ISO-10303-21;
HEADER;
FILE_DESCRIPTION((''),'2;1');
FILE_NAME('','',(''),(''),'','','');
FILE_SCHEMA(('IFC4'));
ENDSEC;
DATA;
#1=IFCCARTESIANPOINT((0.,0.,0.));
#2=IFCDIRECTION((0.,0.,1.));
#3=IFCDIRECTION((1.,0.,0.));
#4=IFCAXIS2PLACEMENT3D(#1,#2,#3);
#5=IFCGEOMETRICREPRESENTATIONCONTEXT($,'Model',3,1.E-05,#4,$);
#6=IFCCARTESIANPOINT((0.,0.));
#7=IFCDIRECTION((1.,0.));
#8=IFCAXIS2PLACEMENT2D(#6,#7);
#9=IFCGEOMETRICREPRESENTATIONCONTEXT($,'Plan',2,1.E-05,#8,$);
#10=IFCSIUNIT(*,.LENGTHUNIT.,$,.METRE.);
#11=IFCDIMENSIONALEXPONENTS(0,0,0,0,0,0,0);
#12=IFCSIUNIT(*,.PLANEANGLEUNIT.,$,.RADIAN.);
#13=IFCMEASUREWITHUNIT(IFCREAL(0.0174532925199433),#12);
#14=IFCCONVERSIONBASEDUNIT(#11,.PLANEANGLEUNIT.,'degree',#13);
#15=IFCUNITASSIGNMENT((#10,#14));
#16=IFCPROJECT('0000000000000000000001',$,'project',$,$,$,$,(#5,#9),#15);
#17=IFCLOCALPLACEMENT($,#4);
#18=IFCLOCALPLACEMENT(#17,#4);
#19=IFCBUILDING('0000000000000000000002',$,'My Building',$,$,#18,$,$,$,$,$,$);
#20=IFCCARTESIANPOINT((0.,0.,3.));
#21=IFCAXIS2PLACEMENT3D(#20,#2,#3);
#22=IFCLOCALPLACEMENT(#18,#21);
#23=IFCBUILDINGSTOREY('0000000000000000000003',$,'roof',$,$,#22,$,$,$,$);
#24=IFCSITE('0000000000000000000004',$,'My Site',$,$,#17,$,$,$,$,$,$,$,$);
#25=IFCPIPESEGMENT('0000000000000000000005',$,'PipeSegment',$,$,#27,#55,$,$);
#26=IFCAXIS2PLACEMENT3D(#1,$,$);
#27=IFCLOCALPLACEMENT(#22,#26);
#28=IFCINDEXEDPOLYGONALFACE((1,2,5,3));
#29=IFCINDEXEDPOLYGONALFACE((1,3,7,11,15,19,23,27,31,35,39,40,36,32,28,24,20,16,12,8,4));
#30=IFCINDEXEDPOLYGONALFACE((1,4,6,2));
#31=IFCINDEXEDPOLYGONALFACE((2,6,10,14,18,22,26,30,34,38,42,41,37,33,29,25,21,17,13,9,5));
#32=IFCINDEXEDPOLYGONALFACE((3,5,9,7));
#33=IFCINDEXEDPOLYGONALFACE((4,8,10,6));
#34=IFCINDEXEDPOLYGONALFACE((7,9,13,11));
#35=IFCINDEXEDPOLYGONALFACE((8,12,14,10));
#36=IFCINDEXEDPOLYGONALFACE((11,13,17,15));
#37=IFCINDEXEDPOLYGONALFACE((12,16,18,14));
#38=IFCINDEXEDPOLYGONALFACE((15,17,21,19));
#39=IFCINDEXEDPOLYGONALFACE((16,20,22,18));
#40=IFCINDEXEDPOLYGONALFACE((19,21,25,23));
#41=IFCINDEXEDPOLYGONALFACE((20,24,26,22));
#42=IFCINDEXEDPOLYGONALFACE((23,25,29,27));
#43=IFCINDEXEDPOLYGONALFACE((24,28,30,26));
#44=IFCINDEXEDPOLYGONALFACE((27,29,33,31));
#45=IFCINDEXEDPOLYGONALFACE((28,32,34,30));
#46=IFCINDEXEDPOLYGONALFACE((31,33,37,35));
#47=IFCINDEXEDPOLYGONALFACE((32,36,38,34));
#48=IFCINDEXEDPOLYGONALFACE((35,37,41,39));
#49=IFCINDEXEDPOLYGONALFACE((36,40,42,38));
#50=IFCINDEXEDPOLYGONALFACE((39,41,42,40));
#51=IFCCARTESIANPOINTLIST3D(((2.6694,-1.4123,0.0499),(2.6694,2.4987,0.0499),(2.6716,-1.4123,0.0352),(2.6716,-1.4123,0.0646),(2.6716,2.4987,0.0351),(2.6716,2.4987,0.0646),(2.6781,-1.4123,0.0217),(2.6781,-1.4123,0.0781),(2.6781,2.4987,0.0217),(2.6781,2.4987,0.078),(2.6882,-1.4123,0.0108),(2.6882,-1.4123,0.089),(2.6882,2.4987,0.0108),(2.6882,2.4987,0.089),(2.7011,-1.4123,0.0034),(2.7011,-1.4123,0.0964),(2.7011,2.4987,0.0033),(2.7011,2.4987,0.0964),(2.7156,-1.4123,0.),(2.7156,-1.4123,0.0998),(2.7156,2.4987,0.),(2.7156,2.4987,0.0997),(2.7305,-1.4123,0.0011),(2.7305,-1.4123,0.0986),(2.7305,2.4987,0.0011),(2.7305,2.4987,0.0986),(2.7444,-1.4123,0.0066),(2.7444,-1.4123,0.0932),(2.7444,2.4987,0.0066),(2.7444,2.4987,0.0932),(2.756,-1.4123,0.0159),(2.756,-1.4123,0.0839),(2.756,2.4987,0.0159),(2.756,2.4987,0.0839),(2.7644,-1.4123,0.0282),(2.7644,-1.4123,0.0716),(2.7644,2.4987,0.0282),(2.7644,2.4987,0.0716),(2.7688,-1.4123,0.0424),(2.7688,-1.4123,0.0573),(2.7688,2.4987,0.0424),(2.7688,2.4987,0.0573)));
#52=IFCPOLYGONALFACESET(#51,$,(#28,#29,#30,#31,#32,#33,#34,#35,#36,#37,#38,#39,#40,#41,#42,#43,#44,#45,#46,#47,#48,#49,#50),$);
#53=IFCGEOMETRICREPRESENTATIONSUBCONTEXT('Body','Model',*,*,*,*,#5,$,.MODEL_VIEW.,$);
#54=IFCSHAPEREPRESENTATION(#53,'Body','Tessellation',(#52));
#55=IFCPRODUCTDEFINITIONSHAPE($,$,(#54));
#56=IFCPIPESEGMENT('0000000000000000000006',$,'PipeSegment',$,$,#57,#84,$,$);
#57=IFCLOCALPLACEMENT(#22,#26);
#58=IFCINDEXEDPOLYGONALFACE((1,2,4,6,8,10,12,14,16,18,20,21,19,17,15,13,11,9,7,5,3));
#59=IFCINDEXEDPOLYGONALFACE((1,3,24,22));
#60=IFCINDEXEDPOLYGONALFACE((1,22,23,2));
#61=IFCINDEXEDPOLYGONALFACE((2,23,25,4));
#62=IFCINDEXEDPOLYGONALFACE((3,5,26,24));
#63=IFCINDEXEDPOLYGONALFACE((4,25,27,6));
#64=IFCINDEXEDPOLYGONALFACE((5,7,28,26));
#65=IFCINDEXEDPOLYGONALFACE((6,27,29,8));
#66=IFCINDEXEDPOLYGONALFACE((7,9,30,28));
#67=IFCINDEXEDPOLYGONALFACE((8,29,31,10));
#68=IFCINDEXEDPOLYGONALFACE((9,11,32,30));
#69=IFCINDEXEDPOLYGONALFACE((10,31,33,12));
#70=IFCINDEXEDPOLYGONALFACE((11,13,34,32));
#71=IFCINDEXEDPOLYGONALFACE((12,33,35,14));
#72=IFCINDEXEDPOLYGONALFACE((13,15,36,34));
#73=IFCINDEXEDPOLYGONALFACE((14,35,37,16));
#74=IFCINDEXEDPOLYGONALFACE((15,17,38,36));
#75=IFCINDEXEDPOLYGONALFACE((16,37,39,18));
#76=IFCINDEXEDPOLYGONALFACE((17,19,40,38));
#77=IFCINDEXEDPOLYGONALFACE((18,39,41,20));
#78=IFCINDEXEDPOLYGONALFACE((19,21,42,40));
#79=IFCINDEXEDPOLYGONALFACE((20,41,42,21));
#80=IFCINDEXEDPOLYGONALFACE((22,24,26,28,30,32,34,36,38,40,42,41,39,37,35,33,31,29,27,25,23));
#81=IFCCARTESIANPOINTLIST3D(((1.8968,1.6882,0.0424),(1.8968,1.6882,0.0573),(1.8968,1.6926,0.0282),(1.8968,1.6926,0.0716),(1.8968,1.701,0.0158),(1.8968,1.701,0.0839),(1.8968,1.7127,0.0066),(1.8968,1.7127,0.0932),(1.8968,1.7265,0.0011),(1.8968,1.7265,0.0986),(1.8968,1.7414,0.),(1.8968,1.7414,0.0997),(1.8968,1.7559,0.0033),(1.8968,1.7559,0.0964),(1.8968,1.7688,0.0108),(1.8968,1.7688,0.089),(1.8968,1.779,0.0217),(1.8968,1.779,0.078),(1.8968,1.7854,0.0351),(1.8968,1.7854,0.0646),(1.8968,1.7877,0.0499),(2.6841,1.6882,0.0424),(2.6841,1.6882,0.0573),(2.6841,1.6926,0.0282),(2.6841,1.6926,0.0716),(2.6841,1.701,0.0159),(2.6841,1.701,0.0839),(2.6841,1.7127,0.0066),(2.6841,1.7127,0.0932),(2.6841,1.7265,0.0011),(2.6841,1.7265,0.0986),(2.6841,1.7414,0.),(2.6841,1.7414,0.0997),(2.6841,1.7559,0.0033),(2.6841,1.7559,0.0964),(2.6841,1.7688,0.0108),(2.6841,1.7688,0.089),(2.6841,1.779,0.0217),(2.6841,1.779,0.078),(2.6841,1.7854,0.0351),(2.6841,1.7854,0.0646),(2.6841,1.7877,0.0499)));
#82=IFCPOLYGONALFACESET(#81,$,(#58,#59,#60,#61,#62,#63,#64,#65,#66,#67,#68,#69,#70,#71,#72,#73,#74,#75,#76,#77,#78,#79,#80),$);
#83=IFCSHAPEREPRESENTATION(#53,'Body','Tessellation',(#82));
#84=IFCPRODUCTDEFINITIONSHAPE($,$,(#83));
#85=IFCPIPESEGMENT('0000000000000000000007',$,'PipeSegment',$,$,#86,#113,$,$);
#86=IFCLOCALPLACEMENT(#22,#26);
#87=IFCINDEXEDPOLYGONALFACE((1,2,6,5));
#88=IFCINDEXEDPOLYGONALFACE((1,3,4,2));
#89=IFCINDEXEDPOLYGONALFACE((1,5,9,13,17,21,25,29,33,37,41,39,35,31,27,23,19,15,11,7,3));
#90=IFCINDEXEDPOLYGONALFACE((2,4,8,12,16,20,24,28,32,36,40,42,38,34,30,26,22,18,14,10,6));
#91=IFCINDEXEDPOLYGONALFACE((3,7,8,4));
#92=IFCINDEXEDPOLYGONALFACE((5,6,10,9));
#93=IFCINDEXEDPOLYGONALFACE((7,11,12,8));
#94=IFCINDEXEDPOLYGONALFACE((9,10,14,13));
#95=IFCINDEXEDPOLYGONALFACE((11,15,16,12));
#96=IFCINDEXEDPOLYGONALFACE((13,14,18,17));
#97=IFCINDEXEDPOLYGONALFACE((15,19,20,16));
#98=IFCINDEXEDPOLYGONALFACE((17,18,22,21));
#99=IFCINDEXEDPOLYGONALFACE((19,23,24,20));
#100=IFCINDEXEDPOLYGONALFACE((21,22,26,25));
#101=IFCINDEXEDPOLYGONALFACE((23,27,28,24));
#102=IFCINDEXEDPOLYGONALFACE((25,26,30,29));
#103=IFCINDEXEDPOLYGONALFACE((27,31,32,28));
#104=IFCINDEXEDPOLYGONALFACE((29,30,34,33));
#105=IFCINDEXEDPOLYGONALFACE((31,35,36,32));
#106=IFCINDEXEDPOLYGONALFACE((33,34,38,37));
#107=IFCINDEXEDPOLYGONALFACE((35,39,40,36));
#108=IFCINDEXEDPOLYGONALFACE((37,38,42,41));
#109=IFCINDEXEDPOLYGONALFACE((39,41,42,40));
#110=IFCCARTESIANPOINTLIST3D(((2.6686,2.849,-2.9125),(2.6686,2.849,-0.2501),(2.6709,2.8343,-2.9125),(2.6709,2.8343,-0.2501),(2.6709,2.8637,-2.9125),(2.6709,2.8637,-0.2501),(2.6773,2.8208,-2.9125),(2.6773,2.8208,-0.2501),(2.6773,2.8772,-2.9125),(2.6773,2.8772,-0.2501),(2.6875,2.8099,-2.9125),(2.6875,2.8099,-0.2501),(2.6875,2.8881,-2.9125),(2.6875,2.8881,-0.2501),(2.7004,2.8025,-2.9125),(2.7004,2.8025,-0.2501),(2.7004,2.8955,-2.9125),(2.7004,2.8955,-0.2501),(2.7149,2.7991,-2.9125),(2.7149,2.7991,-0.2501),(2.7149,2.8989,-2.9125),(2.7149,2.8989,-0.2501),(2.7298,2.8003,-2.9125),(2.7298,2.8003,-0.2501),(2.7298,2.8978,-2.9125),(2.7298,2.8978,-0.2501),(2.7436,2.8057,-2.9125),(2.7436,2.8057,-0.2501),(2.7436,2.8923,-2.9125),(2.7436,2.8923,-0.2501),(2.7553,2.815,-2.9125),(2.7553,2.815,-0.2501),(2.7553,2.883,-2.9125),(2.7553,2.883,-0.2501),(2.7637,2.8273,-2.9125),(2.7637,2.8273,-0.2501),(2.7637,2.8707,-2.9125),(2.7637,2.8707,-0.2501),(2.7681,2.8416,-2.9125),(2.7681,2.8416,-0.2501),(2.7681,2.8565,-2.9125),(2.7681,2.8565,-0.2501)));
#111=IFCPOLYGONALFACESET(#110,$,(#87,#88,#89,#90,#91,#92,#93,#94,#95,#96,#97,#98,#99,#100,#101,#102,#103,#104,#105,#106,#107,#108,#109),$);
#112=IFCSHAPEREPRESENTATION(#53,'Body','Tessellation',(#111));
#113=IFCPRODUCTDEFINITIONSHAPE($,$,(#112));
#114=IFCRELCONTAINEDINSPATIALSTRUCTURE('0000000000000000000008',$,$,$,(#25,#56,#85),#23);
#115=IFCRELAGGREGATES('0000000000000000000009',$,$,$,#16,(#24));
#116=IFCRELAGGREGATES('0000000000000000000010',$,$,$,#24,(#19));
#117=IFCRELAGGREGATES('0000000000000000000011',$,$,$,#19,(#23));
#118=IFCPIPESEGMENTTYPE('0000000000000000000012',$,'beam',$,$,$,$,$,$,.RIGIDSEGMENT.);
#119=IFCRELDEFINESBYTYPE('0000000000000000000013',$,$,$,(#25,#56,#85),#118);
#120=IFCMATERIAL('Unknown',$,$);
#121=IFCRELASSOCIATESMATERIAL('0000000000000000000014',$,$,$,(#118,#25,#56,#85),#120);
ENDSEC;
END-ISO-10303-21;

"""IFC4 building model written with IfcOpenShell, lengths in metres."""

from ifc_helpers import new_model, entity, si_unit, converted_unit, frame, origin_with_axes, origin_2d_with_axis, place, context, subcontext, project, spatial, circle, extrude, material, material_profile, profile_set, profile_usage, type_object, element, save


model = new_model("IFC4")

# Units and contexts
model_context = context("Model", 3, precision=1e-05, world=origin_with_axes())
plan_context = context("Plan", 2, precision=1e-05, world=origin_2d_with_axis())
body_context = subcontext(model_context, "Body", "Model", "MODEL_VIEW")
ifc_project = project(units=[si_unit("LENGTHUNIT", "METRE"), converted_unit("PLANEANGLEUNIT", "degree", entity("IfcReal", 0.0174532925199433), si_unit("PLANEANGLEUNIT", "RADIAN"), dimensions=[0, 0, 0, 0, 0, 0, 0])], contexts=[model_context, plan_context])

# Site, building, storey
site_placement = place(None, origin_with_axes())
site = spatial("IfcSite", under=ifc_project, at=site_placement, Name="My Site")
building_placement = place(site_placement, origin_with_axes())
building = spatial("IfcBuilding", under=site, at=building_placement, Name="My Building")
storey_placement = place(building_placement, frame((0.0, 0.0, 3.0), z_axis=(0.0, 0.0, 1.0), x_axis=(1.0, 0.0, 0.0)))
storey = spatial("IfcBuildingStorey", under=building, at=storey_placement, Name="roof")

# Shared definitions
ifc_material = material(Name="Unknown")

# Pipe segments
ifc_material_profile_1 = material_profile(ifc_material, circle(Radius=0.05))
ifc_profile_set_1 = profile_set([ifc_material_profile_1])
pipe_segment_type = type_object("IfcPipeSegmentType", Name="beam", PredefinedType="RIGIDSEGMENT", material=ifc_profile_set_1)
ifc_profile_usage_1 = profile_usage(ifc_profile_set_1, cardinal=7)
pipe_segment_1_placement = place(storey_placement, frame((2.6694, -1.4123, 0.0999), z_axis=(0.0, 1.0, -0.000003), x_axis=(-1.0, 0.0, 0.0)))
element("IfcPipeSegment", 1, at=pipe_segment_1_placement, inside=storey, type_object=pipe_segment_type, material=ifc_profile_usage_1, Name="PipeSegment", context=body_context, shape_type="SweptSolid", body=[
    extrude(circle(Radius=0.05), frame((-0.05, -0.05, 0.0), z_axis=(0.0, 0.0, 1.0), x_axis=(1.0, 0.0, 0.0)), (0.0, 0.0, 1.0), 3.911),
])
ifc_profile_usage_2 = profile_usage(ifc_profile_set_1, cardinal=7)
pipe_segment_2_placement = place(storey_placement, frame((1.8968, 1.7877, 0.0999), z_axis=(1.0, 0.0, 0.000001), x_axis=(0.0, 1.0, 0.0)))
element("IfcPipeSegment", 2, at=pipe_segment_2_placement, inside=storey, type_object=pipe_segment_type, material=ifc_profile_usage_2, Name="PipeSegment", context=body_context, shape_type="SweptSolid", body=[
    extrude(circle(Radius=0.05), frame((-0.05, -0.05, 0.0), z_axis=(0.0, 0.0, 1.0), x_axis=(1.0, 0.0, 0.0)), (0.0, 0.0, 1.0), 0.7874),
])
ifc_profile_usage_3 = profile_usage(ifc_profile_set_1, cardinal=7)
pipe_segment_3_placement = place(storey_placement, frame((2.6686, 2.899, -0.2501), z_axis=(0.0, 0.0, -1.0), x_axis=(-1.0, 0.0, 0.0)))
element("IfcPipeSegment", 3, at=pipe_segment_3_placement, inside=storey, type_object=pipe_segment_type, material=ifc_profile_usage_3, Name="PipeSegment", context=body_context, shape_type="SweptSolid", body=[
    extrude(circle(Radius=0.05), frame((-0.05, -0.05, 0.0), z_axis=(0.0, 0.0, 1.0), x_axis=(1.0, 0.0, 0.0)), (0.0, 0.0, 1.0), 2.6623),
])

save(model, "model.ifc")
